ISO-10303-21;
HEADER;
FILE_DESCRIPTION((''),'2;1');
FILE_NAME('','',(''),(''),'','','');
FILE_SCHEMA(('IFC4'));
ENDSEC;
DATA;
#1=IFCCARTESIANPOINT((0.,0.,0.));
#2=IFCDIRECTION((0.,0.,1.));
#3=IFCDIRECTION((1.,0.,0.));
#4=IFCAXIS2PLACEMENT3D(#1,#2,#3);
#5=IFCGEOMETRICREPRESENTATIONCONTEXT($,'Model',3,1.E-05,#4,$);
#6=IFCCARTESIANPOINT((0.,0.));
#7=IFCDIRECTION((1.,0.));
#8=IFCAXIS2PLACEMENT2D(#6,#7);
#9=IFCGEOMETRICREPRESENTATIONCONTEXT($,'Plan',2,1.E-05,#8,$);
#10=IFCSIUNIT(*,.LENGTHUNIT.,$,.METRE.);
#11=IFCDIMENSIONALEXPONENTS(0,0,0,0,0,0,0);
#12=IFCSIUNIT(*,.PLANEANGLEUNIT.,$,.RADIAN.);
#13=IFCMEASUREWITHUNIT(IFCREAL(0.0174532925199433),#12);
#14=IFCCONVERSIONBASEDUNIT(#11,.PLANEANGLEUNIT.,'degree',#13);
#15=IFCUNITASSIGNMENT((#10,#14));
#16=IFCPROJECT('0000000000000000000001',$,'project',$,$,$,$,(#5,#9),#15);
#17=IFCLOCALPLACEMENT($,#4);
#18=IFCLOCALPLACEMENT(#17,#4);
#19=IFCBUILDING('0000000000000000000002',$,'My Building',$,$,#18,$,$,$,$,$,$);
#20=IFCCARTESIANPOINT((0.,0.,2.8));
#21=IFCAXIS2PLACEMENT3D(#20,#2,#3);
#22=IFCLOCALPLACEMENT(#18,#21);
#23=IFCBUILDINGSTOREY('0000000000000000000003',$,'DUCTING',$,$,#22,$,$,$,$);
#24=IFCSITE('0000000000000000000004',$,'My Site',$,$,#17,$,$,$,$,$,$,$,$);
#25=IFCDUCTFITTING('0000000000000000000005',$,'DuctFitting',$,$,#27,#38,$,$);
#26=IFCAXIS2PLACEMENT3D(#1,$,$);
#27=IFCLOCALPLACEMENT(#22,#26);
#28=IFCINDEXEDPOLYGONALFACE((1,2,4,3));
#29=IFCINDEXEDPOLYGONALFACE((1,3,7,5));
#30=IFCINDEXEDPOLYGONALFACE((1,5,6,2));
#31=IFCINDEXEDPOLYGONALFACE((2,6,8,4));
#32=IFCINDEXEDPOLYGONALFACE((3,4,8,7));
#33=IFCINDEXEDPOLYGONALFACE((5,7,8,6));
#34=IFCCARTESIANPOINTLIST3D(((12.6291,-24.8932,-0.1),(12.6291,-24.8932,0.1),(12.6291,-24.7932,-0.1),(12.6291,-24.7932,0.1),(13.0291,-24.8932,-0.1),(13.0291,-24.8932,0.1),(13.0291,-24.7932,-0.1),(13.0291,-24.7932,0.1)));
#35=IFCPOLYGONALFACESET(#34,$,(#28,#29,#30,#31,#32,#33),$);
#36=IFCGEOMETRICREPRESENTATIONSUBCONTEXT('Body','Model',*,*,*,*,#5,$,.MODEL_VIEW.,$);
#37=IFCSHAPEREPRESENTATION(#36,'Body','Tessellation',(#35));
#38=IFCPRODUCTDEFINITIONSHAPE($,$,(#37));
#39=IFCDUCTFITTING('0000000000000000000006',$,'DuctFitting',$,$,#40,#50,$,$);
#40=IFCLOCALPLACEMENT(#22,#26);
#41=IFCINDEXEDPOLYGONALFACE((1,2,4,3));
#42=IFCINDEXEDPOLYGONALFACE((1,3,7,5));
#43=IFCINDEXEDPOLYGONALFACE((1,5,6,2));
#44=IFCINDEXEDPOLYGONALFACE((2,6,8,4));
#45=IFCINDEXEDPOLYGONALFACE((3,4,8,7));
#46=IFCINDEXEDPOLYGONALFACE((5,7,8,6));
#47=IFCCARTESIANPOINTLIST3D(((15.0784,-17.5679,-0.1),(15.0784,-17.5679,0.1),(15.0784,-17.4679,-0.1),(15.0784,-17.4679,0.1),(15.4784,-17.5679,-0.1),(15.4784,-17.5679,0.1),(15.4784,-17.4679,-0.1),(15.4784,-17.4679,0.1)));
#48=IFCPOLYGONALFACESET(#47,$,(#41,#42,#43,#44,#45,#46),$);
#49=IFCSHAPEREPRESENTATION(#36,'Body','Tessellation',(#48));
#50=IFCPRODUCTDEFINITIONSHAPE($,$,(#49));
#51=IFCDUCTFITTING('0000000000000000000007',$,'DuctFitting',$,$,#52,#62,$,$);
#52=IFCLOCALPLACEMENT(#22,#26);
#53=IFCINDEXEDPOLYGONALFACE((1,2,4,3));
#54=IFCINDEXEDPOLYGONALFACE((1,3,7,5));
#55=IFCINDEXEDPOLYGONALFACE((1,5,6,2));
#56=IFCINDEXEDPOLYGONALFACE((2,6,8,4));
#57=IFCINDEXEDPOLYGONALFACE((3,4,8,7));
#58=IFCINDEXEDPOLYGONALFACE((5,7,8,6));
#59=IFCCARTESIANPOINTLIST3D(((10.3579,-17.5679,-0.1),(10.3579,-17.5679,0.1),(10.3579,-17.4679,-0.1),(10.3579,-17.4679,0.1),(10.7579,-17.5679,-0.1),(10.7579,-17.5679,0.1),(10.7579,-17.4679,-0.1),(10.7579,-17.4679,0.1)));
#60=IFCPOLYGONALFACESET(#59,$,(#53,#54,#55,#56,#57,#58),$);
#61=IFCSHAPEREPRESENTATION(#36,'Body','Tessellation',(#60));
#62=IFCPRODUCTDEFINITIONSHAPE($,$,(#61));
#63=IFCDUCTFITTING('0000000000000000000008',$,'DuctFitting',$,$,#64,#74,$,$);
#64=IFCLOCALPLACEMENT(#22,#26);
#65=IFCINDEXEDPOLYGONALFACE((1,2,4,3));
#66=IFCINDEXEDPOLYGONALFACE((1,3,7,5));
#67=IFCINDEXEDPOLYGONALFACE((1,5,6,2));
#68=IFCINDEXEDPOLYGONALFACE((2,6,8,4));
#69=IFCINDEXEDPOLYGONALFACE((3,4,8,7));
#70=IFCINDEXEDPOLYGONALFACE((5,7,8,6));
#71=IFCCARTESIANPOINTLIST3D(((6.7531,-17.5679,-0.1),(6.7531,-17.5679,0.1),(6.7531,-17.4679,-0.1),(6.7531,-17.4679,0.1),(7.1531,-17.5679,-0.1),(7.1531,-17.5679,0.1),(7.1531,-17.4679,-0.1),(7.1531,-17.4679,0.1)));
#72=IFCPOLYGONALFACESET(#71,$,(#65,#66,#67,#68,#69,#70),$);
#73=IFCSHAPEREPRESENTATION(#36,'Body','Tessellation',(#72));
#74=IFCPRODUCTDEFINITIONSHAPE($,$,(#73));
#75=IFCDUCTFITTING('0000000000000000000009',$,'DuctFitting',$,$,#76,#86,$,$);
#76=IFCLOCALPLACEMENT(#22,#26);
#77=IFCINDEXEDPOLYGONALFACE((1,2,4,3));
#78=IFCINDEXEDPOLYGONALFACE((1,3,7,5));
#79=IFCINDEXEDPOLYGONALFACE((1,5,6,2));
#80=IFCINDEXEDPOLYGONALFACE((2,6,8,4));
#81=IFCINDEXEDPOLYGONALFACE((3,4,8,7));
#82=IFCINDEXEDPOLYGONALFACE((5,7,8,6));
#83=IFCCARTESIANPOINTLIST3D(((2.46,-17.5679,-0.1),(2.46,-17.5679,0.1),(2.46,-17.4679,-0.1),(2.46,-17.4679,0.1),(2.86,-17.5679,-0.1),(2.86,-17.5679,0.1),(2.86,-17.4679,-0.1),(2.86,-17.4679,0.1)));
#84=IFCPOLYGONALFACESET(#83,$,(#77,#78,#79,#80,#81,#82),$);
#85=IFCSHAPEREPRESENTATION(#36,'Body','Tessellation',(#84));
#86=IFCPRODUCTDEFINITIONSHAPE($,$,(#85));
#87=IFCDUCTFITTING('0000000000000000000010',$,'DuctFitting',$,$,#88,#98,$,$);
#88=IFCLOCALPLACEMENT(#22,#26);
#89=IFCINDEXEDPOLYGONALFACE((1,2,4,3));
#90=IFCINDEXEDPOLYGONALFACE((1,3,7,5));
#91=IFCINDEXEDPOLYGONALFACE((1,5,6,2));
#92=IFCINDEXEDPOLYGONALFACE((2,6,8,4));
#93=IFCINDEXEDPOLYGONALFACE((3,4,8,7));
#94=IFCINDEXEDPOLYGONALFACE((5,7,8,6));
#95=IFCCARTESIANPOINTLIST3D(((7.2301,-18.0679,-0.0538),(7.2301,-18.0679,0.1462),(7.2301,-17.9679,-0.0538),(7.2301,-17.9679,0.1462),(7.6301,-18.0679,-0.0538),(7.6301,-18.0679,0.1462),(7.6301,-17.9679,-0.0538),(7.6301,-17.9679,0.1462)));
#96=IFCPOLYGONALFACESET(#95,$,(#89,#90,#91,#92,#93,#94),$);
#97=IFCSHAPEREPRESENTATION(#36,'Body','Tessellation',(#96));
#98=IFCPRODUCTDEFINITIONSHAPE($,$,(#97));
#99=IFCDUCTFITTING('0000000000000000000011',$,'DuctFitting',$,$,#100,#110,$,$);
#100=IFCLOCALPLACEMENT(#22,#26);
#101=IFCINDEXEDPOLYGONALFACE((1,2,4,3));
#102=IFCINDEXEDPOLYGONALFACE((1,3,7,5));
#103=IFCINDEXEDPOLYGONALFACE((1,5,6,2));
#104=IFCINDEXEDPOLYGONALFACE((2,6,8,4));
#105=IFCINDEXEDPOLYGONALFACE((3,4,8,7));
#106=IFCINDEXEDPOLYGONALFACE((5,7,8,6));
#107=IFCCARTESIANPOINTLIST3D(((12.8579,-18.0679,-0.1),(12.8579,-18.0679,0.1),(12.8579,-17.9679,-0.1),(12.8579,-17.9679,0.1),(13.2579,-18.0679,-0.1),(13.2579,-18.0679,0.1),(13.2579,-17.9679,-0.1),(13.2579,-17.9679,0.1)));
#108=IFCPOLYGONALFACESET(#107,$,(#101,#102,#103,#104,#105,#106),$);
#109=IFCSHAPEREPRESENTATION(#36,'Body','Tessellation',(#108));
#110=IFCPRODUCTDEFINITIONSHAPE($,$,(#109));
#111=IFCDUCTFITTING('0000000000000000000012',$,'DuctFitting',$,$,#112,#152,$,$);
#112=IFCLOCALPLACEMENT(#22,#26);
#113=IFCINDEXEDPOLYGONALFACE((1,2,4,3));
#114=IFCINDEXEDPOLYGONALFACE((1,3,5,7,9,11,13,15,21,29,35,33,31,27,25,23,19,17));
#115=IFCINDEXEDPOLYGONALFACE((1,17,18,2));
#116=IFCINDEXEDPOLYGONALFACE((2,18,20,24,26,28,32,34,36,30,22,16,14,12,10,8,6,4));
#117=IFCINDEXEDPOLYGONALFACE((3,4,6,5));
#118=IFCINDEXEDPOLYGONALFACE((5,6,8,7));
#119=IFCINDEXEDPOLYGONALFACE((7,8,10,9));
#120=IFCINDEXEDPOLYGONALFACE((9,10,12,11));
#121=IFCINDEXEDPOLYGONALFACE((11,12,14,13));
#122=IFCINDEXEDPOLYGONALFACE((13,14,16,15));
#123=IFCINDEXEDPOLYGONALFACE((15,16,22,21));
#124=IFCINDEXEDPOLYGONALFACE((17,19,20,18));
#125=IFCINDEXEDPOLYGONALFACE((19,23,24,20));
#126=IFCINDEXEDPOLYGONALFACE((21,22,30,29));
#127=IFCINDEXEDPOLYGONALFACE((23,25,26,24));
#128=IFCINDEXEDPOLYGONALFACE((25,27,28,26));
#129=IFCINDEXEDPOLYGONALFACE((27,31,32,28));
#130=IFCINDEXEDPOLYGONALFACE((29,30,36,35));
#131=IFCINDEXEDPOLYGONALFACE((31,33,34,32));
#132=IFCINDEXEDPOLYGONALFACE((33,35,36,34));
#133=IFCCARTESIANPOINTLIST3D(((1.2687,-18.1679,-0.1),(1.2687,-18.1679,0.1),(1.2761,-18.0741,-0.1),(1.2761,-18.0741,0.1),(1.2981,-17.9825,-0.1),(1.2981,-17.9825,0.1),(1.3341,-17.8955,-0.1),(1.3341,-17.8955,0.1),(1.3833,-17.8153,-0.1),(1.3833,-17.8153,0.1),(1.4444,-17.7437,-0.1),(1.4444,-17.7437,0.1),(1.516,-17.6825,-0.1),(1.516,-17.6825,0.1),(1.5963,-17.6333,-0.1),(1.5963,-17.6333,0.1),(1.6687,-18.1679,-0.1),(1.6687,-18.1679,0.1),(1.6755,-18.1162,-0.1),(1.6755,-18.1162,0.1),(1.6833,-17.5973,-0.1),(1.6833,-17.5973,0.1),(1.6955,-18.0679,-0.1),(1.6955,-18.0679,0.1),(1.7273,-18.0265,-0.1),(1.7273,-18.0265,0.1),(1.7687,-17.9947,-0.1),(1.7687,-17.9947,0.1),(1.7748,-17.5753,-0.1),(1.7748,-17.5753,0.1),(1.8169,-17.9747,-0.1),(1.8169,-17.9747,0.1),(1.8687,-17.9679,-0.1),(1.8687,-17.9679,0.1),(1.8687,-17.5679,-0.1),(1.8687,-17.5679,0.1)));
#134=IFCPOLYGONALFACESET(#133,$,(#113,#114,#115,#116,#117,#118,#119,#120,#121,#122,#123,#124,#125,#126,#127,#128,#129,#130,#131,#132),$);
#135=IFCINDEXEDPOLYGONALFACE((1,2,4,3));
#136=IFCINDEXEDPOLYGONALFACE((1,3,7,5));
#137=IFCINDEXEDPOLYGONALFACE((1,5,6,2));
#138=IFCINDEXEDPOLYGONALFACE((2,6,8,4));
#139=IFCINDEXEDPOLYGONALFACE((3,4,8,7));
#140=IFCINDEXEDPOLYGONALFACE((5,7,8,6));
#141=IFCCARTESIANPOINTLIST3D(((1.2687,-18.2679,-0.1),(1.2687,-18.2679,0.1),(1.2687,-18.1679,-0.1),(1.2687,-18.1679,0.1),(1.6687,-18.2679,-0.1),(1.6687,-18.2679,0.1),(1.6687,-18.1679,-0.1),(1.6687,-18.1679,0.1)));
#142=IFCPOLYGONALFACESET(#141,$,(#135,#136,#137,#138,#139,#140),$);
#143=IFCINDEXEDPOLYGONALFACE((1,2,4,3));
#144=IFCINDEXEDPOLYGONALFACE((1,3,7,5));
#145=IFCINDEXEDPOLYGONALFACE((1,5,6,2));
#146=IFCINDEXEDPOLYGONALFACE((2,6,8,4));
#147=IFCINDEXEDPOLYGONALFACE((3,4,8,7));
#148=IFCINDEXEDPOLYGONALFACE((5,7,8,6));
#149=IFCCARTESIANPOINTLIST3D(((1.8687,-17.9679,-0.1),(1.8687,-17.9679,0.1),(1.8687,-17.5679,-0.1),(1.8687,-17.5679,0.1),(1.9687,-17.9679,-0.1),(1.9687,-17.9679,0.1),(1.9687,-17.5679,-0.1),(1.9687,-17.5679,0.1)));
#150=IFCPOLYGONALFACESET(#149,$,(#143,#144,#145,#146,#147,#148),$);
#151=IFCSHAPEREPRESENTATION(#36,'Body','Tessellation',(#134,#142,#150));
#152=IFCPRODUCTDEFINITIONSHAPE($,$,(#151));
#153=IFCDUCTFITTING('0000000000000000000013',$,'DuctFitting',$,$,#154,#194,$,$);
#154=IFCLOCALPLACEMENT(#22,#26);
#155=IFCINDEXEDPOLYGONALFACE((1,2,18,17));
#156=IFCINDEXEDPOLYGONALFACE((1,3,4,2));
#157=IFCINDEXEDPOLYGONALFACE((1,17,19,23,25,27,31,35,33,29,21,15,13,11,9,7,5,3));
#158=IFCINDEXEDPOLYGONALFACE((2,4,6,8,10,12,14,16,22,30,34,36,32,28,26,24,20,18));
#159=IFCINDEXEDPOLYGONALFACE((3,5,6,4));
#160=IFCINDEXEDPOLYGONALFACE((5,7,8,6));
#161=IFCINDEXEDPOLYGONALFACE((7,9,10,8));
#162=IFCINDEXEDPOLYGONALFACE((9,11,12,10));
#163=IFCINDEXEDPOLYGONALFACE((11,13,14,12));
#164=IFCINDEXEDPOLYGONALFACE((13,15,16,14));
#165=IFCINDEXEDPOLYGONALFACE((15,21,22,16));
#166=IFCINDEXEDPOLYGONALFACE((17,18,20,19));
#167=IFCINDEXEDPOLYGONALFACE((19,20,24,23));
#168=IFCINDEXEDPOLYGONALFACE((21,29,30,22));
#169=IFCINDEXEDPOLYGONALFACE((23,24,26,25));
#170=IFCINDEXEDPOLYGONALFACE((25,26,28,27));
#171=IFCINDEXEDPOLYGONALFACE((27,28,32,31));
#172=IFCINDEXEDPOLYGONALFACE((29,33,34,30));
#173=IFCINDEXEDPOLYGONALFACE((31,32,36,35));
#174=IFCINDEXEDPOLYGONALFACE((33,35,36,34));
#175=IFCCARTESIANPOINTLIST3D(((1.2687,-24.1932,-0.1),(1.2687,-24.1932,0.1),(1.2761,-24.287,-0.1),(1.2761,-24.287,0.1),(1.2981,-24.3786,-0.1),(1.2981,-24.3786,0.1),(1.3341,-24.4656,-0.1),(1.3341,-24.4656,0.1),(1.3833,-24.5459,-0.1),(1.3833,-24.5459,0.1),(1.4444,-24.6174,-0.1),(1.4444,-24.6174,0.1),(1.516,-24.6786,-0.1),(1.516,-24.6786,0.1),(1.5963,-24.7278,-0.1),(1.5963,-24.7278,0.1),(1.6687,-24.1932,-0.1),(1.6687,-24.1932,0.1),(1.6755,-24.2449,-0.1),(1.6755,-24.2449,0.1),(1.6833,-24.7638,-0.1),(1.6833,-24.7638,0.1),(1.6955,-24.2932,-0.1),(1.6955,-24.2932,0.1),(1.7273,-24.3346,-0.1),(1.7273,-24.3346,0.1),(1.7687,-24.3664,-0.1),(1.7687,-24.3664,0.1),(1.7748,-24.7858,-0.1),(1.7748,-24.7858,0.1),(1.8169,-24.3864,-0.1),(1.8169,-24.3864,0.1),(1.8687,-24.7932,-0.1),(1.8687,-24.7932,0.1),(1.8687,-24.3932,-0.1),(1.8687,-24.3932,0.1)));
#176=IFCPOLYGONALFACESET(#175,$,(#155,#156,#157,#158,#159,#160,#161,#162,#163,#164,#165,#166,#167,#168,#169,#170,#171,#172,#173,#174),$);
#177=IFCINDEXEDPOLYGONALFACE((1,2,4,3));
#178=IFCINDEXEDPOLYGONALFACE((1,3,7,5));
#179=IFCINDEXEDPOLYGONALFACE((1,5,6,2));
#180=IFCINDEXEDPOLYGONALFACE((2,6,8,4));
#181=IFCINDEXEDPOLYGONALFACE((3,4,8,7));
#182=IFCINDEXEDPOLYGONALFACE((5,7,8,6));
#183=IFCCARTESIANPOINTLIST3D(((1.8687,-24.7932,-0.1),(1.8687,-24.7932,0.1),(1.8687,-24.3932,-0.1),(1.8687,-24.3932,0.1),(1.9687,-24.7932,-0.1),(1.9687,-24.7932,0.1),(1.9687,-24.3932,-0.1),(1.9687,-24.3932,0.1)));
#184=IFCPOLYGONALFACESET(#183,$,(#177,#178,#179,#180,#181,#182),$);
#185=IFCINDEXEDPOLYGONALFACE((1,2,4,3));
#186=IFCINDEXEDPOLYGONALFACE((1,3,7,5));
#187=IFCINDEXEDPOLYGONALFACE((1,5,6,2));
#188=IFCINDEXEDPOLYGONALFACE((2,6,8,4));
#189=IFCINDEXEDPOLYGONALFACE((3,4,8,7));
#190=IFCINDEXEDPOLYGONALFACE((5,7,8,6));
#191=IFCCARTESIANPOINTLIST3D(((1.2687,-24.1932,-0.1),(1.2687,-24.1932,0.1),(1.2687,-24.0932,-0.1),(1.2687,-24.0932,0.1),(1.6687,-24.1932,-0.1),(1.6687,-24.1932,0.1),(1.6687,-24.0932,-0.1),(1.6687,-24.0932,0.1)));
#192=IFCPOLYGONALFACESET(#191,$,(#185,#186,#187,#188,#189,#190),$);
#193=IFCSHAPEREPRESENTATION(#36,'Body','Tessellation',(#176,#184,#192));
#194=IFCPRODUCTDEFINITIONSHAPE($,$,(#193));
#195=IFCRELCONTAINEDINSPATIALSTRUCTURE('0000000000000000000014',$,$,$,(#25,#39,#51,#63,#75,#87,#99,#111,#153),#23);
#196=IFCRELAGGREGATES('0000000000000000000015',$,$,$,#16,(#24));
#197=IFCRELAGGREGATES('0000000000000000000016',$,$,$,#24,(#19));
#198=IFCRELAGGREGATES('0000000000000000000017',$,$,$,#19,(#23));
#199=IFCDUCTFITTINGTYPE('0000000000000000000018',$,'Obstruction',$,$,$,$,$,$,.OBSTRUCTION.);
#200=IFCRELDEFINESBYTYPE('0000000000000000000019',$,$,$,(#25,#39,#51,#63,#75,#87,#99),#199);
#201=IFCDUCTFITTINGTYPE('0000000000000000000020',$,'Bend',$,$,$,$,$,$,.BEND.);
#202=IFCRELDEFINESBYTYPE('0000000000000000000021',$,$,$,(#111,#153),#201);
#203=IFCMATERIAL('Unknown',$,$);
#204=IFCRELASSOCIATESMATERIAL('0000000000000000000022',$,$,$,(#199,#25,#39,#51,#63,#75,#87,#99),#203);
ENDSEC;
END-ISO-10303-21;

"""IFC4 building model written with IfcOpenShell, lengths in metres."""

from ifc_helpers import new_model, entity, si_unit, converted_unit, frame, origin_with_axes, origin_2d_with_axis, place, context, subcontext, project, spatial, line, arc, indexed_curve, rectangle, outline, extrude, source, transform, mapped, material, material_profile, profile_set, profile_usage, type_object, type_shapes, element, save


model = new_model("IFC4")

# Units and contexts
model_context = context("Model", 3, precision=1e-05, world=origin_with_axes())
plan_context = context("Plan", 2, precision=1e-05, world=origin_2d_with_axis())
body_context = subcontext(model_context, "Body", "Model", "MODEL_VIEW")
ifc_project = project(units=[si_unit("LENGTHUNIT", "METRE"), converted_unit("PLANEANGLEUNIT", "degree", entity("IfcReal", 0.0174532925199433), si_unit("PLANEANGLEUNIT", "RADIAN"), dimensions=[0, 0, 0, 0, 0, 0, 0])], contexts=[model_context, plan_context])

# Site, building, storey
site_placement = place(None, origin_with_axes())
site = spatial("IfcSite", under=ifc_project, at=site_placement, Name="My Site")
building_placement = place(site_placement, origin_with_axes())
building = spatial("IfcBuilding", under=site, at=building_placement, Name="My Building")
storey_placement = place(building_placement, frame((0.0, 0.0, 2.8), z_axis=(0.0, 0.0, 1.0), x_axis=(1.0, 0.0, 0.0)))
storey = spatial("IfcBuildingStorey", under=building, at=storey_placement, Name="DUCTING")

# Shared definitions
ifc_material = material(Name="Unknown")

# Duct fittings
ifc_material_profile_1 = material_profile(ifc_material, rectangle(XDim=0.4, YDim=0.2))
ifc_profile_set_1 = profile_set([ifc_material_profile_1])
duct_fitting_type_1 = type_object("IfcDuctFittingType", Name="Obstruction", PredefinedType="OBSTRUCTION", material=ifc_profile_set_1)
ifc_profile_usage_1 = profile_usage(ifc_profile_set_1, cardinal=5)
duct_fitting_1_placement = place(storey_placement, frame((12.8291, -24.8932, 0.0), z_axis=(0.0, 1.0, 0.0), x_axis=(-1.0, 0.0, 0.0)))
element("IfcDuctFitting", 1, at=duct_fitting_1_placement, inside=storey, type_object=duct_fitting_type_1, material=ifc_profile_usage_1, Name="DuctFitting", context=body_context, shape_type="SweptSolid", body=[
    extrude(rectangle(XDim=0.4, YDim=0.2), origin_with_axes(), (0.0, 0.0, 1.0), 0.1),
])
ifc_profile_usage_2 = profile_usage(ifc_profile_set_1, cardinal=5)
duct_fitting_2_placement = place(storey_placement, frame((15.2784, -17.4679, 0.0), z_axis=(0.0, -1.0, 0.0), x_axis=(1.0, 0.0, 0.0)))
element("IfcDuctFitting", 2, at=duct_fitting_2_placement, inside=storey, type_object=duct_fitting_type_1, material=ifc_profile_usage_2, Name="DuctFitting", context=body_context, shape_type="SweptSolid", body=[
    extrude(rectangle(XDim=0.4, YDim=0.2), origin_with_axes(), (0.0, 0.0, 1.0), 0.1),
])
ifc_profile_usage_3 = profile_usage(ifc_profile_set_1, cardinal=5)
duct_fitting_3_placement = place(storey_placement, frame((10.5579, -17.4679, 0.0), z_axis=(0.0, -1.0, 0.0), x_axis=(1.0, 0.0, 0.0)))
element("IfcDuctFitting", 3, at=duct_fitting_3_placement, inside=storey, type_object=duct_fitting_type_1, material=ifc_profile_usage_3, Name="DuctFitting", context=body_context, shape_type="SweptSolid", body=[
    extrude(rectangle(XDim=0.4, YDim=0.2), origin_with_axes(), (0.0, 0.0, 1.0), 0.1),
])
ifc_profile_usage_4 = profile_usage(ifc_profile_set_1, cardinal=5)
duct_fitting_4_placement = place(storey_placement, frame((6.9531, -17.4679, 0.0), z_axis=(0.0, -1.0, 0.0), x_axis=(1.0, 0.0, 0.0)))
element("IfcDuctFitting", 4, at=duct_fitting_4_placement, inside=storey, type_object=duct_fitting_type_1, material=ifc_profile_usage_4, Name="DuctFitting", context=body_context, shape_type="SweptSolid", body=[
    extrude(rectangle(XDim=0.4, YDim=0.2), origin_with_axes(), (0.0, 0.0, 1.0), 0.1),
])
ifc_profile_usage_5 = profile_usage(ifc_profile_set_1, cardinal=5)
duct_fitting_5_placement = place(storey_placement, frame((2.66, -17.4679, 0.0), z_axis=(0.0, -1.0, 0.0), x_axis=(1.0, 0.0, 0.0)))
element("IfcDuctFitting", 5, at=duct_fitting_5_placement, inside=storey, type_object=duct_fitting_type_1, material=ifc_profile_usage_5, Name="DuctFitting", context=body_context, shape_type="SweptSolid", body=[
    extrude(rectangle(XDim=0.4, YDim=0.2), origin_with_axes(), (0.0, 0.0, 1.0), 0.1),
])
ifc_profile_usage_6 = profile_usage(ifc_profile_set_1, cardinal=5)
duct_fitting_6_placement = place(storey_placement, frame((7.4301, -18.0679, 0.0462), z_axis=(0.0, 1.0, 0.0), x_axis=(-1.0, 0.0, 0.0)))
element("IfcDuctFitting", 6, at=duct_fitting_6_placement, inside=storey, type_object=duct_fitting_type_1, material=ifc_profile_usage_6, Name="DuctFitting", context=body_context, shape_type="SweptSolid", body=[
    extrude(rectangle(XDim=0.4, YDim=0.2), origin_with_axes(), (0.0, 0.0, 1.0), 0.1),
])
ifc_profile_usage_7 = profile_usage(ifc_profile_set_1, cardinal=5)
duct_fitting_7_placement = place(storey_placement, frame((13.0579, -18.0679, 0.0), z_axis=(0.0, 1.0, 0.0), x_axis=(-1.0, 0.0, 0.0)))
element("IfcDuctFitting", 7, at=duct_fitting_7_placement, inside=storey, type_object=duct_fitting_type_1, material=ifc_profile_usage_7, Name="DuctFitting", context=body_context, shape_type="SweptSolid", body=[
    extrude(rectangle(XDim=0.4, YDim=0.2), origin_with_axes(), (0.0, 0.0, 1.0), 0.1),
])
duct_fitting_type_2 = type_object("IfcDuctFittingType", Name="Bend", PredefinedType="BEND")
shared_shape = source(origin_with_axes(), body_context, "Body", "SweptSolid", [
    extrude(outline(indexed_curve([(0.2, 0.0), (0.2586, -0.1414), (0.4, -0.2), (0.4, -0.6), (-0.0243, -0.4243), (-0.2, 0.0)], segments=[arc(1, 2, 3), line(3, 4), arc(4, 5, 6), line(6, 1)])), frame((0.0, -0.1, -0.1), z_axis=(0.0, -1.0, 0.0), x_axis=(1.0, 0.0, 0.0)), (0.0, 0.0, -1.0), 0.2),
    extrude(rectangle(XDim=0.4, YDim=0.2), origin_with_axes(), (0.0, 0.0, -1.0), 0.1),
    extrude(rectangle(XDim=0.4, YDim=0.2), frame((0.4, 0.0, -0.5), z_axis=(1.0, 0.0, 0.0), x_axis=(0.0, 0.0, 1.0)), (0.0, 0.0, 1.0), 0.1),
])
type_shapes(duct_fitting_type_2, [shared_shape])
for number, where, z_axis, x_axis, name in (
    (8, (1.4687, -18.2679, 0.0), (0.0, -1.0, 0.0), (1.0, 0.0, 0.0), "DuctFitting"),
    (9, (1.9687, -24.5932, 0.0), (1.0, 0.0, 0.0), (0.0, 1.0, 0.0), "DuctFitting"),
):
    element("IfcDuctFitting", number, at=place(storey_placement, frame(where, z_axis=z_axis, x_axis=x_axis)), inside=storey, type_object=duct_fitting_type_2, Name=name, context=body_context, shape_type="MappedRepresentation", body=[
        mapped(shared_shape, transform((0.0, 0.0, 0.0), x_axis=(1.0, 0.0, 0.0), y_axis=(0.0, 1.0, 0.0), z_axis=(0.0, 0.0, 1.0), scale=1.0)),
    ])

save(model, "model.ifc")
